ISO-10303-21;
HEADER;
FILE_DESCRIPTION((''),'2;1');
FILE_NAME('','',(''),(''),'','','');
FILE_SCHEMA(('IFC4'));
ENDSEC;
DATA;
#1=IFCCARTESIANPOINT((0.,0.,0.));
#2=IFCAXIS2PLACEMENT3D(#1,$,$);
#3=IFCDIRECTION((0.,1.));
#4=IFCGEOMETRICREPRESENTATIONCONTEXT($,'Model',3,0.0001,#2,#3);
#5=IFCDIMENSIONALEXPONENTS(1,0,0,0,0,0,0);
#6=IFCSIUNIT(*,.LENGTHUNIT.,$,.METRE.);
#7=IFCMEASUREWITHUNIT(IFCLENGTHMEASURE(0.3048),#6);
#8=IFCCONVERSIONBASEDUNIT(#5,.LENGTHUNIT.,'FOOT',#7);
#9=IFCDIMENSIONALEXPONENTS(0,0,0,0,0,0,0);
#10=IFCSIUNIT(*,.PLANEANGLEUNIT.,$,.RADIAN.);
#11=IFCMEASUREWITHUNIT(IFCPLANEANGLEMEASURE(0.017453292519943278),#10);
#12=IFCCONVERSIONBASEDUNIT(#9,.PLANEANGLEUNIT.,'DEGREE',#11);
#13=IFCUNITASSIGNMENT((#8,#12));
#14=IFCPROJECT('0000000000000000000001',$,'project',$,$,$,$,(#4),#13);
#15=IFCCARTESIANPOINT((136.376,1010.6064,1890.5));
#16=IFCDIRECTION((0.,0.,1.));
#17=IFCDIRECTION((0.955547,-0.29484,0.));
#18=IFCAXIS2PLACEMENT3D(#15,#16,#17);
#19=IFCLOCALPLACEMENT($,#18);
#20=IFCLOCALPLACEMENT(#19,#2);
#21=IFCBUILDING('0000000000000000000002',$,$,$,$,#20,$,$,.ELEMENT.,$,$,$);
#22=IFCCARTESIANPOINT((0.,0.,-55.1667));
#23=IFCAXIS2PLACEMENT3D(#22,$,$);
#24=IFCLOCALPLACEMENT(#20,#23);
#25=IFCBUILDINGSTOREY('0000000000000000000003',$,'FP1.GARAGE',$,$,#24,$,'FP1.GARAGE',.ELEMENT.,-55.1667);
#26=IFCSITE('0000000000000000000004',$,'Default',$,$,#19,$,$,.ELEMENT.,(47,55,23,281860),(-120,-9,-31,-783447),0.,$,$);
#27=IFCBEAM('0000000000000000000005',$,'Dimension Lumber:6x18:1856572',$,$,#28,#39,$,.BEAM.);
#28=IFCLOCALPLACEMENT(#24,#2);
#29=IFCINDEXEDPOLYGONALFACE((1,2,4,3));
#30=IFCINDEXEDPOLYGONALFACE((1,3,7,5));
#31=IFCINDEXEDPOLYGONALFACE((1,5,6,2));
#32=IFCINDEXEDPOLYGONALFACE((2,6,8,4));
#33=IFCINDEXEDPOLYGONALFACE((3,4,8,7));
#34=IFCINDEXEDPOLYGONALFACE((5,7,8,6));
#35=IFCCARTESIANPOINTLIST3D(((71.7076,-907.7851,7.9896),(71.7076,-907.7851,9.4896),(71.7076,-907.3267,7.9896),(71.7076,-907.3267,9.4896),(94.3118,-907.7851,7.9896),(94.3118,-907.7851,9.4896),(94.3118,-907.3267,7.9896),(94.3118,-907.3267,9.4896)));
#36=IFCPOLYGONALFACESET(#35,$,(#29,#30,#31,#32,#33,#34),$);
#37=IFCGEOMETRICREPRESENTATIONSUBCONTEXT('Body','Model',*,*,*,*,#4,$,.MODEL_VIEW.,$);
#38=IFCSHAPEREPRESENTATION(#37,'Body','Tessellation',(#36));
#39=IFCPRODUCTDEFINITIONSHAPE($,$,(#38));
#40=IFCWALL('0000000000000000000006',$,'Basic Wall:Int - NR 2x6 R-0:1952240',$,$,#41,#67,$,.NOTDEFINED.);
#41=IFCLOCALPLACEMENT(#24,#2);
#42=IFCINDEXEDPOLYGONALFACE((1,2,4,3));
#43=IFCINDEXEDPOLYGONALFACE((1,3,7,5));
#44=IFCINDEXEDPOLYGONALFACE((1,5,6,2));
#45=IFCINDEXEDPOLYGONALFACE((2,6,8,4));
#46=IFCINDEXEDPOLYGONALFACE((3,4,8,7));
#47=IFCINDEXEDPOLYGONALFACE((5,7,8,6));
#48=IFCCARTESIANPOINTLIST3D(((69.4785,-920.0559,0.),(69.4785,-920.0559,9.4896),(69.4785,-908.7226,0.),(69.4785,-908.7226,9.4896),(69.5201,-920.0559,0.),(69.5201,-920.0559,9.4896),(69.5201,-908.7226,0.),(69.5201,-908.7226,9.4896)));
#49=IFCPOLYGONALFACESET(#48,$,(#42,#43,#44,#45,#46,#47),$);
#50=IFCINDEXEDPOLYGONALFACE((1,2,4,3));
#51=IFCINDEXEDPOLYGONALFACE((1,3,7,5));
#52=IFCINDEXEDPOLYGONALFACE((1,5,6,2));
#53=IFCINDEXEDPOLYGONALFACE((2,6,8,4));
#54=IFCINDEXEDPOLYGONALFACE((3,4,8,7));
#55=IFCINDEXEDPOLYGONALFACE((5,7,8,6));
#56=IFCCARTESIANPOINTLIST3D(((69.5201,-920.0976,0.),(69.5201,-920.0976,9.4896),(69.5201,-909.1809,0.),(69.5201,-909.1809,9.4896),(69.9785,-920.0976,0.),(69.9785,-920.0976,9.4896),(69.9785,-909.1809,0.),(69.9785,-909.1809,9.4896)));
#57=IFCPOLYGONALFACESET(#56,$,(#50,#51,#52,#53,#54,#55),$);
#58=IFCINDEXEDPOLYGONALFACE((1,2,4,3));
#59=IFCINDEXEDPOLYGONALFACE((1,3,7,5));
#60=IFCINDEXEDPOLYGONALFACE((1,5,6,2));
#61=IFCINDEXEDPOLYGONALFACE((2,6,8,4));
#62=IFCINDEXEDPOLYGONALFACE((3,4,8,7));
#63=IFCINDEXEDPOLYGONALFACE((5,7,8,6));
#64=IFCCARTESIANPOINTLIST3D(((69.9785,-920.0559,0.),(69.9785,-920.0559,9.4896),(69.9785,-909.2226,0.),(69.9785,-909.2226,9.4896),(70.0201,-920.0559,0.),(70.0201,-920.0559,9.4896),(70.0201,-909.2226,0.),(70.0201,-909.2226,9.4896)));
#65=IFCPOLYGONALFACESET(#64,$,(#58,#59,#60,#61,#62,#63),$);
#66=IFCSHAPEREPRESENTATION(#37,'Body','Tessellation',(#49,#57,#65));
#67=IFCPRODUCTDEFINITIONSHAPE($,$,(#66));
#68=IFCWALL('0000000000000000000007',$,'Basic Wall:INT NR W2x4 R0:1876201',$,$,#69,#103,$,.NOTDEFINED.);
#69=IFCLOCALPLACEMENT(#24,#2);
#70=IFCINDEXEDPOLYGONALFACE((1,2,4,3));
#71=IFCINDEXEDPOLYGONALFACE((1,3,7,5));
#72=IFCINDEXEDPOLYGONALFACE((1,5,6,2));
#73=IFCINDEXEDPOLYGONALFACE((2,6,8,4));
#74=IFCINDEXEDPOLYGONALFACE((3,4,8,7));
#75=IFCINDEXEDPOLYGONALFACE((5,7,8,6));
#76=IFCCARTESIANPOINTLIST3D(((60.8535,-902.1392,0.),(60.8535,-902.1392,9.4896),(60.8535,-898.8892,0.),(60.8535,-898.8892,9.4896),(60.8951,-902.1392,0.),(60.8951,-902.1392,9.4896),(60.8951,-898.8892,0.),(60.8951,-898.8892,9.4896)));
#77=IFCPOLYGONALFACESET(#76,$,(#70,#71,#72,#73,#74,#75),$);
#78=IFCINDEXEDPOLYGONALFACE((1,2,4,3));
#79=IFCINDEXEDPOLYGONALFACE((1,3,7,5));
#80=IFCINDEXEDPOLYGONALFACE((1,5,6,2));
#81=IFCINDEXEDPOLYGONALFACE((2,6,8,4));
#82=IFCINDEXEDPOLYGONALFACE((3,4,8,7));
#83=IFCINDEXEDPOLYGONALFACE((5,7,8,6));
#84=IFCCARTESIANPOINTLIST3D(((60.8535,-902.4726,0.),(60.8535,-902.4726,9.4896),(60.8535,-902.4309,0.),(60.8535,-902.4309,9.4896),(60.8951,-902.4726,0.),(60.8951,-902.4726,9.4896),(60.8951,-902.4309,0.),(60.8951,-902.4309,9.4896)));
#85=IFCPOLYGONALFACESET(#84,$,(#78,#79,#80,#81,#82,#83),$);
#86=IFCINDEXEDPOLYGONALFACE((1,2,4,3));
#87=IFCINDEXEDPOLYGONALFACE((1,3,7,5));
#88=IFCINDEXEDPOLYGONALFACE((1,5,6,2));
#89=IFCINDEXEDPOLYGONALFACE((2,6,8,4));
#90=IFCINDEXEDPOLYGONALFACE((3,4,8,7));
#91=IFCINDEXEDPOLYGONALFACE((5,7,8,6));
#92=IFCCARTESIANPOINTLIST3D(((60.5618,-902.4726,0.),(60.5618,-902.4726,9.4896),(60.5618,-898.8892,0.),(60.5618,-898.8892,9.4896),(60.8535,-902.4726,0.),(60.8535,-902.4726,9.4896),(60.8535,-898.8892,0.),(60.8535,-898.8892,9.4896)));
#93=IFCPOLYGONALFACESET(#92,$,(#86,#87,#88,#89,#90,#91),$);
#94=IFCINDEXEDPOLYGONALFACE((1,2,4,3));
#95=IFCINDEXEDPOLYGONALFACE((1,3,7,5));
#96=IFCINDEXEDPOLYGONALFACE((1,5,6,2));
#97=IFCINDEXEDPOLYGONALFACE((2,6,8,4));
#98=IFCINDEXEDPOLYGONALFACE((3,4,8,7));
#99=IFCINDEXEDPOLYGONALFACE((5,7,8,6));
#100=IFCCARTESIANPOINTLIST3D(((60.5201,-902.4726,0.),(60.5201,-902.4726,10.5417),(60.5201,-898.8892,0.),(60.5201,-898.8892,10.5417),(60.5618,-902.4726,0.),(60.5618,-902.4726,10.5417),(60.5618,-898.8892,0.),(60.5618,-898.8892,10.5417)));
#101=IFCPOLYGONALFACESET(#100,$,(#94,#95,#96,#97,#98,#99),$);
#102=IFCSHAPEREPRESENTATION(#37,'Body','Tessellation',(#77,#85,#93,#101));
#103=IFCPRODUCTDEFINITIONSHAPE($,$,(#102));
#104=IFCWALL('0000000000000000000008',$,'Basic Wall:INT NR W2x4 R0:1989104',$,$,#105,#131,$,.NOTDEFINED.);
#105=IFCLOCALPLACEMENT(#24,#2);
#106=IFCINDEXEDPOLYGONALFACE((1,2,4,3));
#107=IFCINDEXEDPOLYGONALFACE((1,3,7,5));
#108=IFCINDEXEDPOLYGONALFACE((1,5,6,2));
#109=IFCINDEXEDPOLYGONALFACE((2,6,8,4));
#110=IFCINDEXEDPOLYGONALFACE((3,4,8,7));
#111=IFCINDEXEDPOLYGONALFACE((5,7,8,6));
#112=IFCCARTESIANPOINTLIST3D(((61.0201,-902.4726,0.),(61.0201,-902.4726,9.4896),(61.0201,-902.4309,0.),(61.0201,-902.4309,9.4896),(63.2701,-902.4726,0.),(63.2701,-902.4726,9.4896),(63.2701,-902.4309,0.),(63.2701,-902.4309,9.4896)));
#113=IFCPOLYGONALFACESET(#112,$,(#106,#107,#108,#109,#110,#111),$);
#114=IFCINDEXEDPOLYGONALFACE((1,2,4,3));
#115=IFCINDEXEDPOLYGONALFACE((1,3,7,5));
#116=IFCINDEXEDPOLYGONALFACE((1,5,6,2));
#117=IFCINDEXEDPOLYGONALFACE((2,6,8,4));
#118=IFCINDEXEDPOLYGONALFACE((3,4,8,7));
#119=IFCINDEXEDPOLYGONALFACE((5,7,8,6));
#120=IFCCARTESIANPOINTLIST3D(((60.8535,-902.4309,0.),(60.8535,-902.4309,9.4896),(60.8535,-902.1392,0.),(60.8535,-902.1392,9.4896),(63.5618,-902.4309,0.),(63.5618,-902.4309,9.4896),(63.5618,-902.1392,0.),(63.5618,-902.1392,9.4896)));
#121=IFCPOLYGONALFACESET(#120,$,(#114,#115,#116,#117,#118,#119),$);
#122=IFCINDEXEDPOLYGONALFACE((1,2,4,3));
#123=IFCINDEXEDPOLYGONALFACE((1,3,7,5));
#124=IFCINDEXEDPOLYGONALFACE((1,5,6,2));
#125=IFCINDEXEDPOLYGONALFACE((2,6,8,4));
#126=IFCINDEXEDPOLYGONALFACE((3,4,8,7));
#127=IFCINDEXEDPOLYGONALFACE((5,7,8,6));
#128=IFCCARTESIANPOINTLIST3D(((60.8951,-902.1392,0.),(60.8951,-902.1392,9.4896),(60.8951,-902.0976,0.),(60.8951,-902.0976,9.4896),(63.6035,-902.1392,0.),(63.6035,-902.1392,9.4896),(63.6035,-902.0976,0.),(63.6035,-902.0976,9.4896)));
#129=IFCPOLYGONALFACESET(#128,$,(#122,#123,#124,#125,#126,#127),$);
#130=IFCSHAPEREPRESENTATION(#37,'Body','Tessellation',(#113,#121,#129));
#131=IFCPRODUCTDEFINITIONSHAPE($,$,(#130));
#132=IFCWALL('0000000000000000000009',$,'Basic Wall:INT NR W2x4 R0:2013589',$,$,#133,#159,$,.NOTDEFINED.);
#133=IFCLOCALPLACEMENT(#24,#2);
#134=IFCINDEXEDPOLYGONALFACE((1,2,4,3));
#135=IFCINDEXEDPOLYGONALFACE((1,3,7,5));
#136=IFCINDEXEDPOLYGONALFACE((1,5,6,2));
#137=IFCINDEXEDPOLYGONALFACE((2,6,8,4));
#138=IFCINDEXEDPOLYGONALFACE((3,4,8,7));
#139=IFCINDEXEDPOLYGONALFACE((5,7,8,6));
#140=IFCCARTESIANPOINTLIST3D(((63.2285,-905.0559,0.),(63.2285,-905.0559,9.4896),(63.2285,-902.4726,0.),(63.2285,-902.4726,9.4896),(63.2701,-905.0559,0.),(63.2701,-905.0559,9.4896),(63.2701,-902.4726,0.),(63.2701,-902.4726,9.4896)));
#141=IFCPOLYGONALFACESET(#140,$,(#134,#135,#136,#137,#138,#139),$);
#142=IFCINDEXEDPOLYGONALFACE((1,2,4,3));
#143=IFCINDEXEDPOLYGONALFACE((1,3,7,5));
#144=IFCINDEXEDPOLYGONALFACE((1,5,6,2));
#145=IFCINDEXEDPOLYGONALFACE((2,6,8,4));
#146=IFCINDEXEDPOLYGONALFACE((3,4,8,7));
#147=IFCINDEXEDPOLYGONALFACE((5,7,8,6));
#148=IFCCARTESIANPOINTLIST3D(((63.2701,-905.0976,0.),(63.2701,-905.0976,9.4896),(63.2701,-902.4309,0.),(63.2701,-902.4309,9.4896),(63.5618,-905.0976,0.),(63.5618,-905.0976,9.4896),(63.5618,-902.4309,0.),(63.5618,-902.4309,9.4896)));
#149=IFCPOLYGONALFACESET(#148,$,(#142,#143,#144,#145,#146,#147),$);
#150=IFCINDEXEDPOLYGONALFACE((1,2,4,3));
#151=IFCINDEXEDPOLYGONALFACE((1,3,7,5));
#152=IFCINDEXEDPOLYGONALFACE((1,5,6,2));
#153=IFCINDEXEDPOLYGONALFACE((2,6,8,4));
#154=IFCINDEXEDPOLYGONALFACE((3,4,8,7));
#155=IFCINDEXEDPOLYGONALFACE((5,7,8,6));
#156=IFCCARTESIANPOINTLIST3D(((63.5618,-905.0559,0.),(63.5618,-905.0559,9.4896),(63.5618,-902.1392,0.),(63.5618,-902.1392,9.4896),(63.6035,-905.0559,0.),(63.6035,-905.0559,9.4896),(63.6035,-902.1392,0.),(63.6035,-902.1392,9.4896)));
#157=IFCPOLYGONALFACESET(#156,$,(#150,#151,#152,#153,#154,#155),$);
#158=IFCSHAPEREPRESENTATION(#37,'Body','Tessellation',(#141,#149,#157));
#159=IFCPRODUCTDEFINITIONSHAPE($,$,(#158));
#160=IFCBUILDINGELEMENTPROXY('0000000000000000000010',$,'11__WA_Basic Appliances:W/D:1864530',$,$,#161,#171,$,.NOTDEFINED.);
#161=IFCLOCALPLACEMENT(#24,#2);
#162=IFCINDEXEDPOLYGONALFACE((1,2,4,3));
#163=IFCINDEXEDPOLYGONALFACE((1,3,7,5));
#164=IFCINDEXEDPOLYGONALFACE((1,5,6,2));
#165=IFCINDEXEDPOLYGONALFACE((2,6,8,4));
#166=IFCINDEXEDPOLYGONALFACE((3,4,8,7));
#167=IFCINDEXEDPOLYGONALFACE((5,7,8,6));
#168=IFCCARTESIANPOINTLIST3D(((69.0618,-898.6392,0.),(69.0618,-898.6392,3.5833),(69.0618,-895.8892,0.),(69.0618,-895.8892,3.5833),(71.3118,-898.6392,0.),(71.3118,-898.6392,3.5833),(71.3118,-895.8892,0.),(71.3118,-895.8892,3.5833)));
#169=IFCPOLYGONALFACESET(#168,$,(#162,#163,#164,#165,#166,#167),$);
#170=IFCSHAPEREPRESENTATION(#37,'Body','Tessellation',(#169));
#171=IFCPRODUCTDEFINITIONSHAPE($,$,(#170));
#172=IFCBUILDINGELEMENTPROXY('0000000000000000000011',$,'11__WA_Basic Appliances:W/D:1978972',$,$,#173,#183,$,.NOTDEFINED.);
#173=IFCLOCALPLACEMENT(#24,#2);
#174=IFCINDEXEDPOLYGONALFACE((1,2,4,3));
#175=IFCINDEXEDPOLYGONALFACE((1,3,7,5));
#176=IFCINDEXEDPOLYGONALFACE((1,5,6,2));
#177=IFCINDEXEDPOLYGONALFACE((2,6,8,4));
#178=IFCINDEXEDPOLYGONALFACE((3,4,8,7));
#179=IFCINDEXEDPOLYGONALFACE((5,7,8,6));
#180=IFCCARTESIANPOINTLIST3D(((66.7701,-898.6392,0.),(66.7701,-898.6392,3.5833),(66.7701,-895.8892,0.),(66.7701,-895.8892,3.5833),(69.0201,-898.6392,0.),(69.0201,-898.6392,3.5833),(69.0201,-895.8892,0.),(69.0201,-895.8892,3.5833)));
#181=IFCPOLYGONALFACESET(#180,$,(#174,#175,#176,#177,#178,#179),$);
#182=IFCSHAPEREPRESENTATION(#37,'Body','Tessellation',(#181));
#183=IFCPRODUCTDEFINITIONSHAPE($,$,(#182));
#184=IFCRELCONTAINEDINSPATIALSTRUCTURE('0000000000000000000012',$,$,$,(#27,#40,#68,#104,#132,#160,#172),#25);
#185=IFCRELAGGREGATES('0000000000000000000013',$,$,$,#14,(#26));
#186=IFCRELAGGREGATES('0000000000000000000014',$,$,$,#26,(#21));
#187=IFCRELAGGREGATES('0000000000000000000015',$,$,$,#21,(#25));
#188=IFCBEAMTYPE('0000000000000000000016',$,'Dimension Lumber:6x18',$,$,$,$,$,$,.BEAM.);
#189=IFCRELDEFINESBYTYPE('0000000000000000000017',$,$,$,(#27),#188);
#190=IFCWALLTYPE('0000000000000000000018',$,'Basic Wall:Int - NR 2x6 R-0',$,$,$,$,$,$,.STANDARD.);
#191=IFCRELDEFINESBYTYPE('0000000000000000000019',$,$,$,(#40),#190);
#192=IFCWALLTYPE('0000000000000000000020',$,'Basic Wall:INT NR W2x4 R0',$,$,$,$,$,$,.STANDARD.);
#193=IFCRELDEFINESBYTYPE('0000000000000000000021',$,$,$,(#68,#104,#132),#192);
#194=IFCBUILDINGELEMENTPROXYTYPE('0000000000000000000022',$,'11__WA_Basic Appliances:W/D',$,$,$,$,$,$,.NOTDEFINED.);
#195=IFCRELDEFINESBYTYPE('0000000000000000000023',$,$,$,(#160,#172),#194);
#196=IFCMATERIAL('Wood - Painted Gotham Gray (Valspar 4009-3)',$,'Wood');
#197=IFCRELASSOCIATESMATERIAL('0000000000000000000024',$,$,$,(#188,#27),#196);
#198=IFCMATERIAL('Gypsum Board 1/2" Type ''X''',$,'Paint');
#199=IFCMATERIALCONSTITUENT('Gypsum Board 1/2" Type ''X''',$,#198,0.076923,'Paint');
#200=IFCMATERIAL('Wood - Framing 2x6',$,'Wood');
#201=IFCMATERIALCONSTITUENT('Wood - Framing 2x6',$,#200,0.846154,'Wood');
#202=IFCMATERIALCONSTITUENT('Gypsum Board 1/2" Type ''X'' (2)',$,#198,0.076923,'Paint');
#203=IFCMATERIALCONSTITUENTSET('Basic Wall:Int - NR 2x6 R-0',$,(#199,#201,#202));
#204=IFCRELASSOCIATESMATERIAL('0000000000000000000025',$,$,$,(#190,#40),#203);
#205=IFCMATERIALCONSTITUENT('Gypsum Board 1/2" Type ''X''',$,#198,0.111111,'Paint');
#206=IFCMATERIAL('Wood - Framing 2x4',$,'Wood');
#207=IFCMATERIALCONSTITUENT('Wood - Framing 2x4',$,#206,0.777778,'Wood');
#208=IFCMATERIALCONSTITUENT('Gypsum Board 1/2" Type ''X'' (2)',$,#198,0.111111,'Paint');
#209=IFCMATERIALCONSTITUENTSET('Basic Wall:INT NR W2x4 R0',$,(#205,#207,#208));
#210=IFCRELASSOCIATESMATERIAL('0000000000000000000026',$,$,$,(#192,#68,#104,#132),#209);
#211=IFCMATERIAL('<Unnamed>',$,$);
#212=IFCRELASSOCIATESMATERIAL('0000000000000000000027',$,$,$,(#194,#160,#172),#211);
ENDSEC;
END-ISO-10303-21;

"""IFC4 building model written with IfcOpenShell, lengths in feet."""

from ifc_helpers import new_model, entity, si_unit, converted_unit, direction, frame, origin, place, context, subcontext, project, spatial, indexed_curve, outline, extrude, source, transform, mapped, material, constituent, constituent_set, type_object, type_shapes, element, save


model = new_model("IFC4")

# Units and contexts
model_context = context("Model", 3, precision=0.0001, world=origin(), true_north=direction((0.0, 1.0)))
body_context = subcontext(model_context, "Body", "Model", "MODEL_VIEW")
ifc_project = project(units=[converted_unit("LENGTHUNIT", "FOOT", entity("IfcLengthMeasure", 0.3048), si_unit("LENGTHUNIT", "METRE"), dimensions=[1, 0, 0, 0, 0, 0, 0]), converted_unit("PLANEANGLEUNIT", "DEGREE", entity("IfcPlaneAngleMeasure", 0.017453292519943278), si_unit("PLANEANGLEUNIT", "RADIAN"), dimensions=[0, 0, 0, 0, 0, 0, 0])], contexts=[model_context])

# Site, building, storey
site_placement = place(None, frame((136.376, 1010.6064, 1890.5), z_axis=(0.0, 0.0, 1.0), x_axis=(0.955547, -0.29484, 0.0)))
site = spatial("IfcSite", under=ifc_project, at=site_placement, Name="Default", CompositionType="ELEMENT", RefLatitude=(47, 55, 23, 281860), RefLongitude=(-120, -9, -31, -783447), RefElevation=0.0)
building_placement = place(site_placement, origin())
building = spatial("IfcBuilding", under=site, at=building_placement, CompositionType="ELEMENT")
storey_placement = place(building_placement, frame((0.0, 0.0, -55.1667)))
storey = spatial("IfcBuildingStorey", under=building, at=storey_placement, Name="FP1.GARAGE", LongName="FP1.GARAGE", CompositionType="ELEMENT", Elevation=-55.1667)

# Beam
ifc_material_1 = material(Name="Wood - Painted Gotham Gray (Valspar 4009-3)", Category="Wood")
beam_type = type_object("IfcBeamType", Name="Dimension Lumber:6x18", PredefinedType="BEAM", material=ifc_material_1)
shared_shape_1 = source(origin(), body_context, "Body", "SweptSolid", [
    extrude(outline(indexed_curve([(-0.75, -0.2292), (0.75, -0.2292), (0.75, 0.2292), (-0.75, 0.2292), (-0.75, -0.2292)], self_intersect=False)), frame((-11.3021, 0.0, 0.0), z_axis=(1.0, 0.0, 0.0), x_axis=(0.0, 0.0, -1.0)), (0.0, 0.0, 1.0), 22.6042),
])
type_shapes(beam_type, [shared_shape_1])
beam_placement = place(storey_placement, frame((83.0097, -907.5559, 8.7396)))
element("IfcBeam", 1, at=beam_placement, inside=storey, type_object=beam_type, material=ifc_material_1, Name="Dimension Lumber:6x18:1856572", PredefinedType="BEAM", context=body_context, shape_type="MappedRepresentation", body=[
    mapped(shared_shape_1, transform((0.0, 0.0, 0.0), scale=1.0)),
])

# Shared definitions
ifc_material_2 = material(Name="Gypsum Board 1/2\" Type 'X'", Category="Paint")
ifc_material_3 = material(Name="<Unnamed>")

# Walls
ifc_constituent_1 = constituent(ifc_material_2, Name="Gypsum Board 1/2\" Type 'X'", Category="Paint", fraction=0.076923)
ifc_material_4 = material(Name="Wood - Framing 2x6", Category="Wood")
ifc_constituent_2 = constituent(ifc_material_4, Name="Wood - Framing 2x6", Category="Wood", fraction=0.846154)
ifc_constituent_3 = constituent(ifc_material_2, Name="Gypsum Board 1/2\" Type 'X' (2)", Category="Paint", fraction=0.076923)
ifc_constituent_set_1 = constituent_set(constituents=[ifc_constituent_1, ifc_constituent_2, ifc_constituent_3], Name="Basic Wall:Int - NR 2x6 R-0")
wall_type_1 = type_object("IfcWallType", Name="Basic Wall:Int - NR 2x6 R-0", PredefinedType="STANDARD", material=ifc_constituent_set_1)
wall_1_placement = place(storey_placement, frame((69.7493, -920.0559, 0.0), z_axis=(0.0, 0.0, 1.0), x_axis=(0.0, 1.0, 0.0)))
element("IfcWall", 2, at=wall_1_placement, inside=storey, type_object=wall_type_1, material=ifc_constituent_set_1, Name="Basic Wall:Int - NR 2x6 R-0:1952240", PredefinedType="NOTDEFINED", context=body_context, shape_type="SweptSolid", body=[
    extrude(outline(indexed_curve([(-0.0208, -5.6667), (0.0208, -5.6667), (0.0208, 5.6667), (-0.0208, 5.6667), (-0.0208, -5.6667)], self_intersect=False)), frame((5.6667, 0.25, 0.0), z_axis=(0.0, 0.0, 1.0), x_axis=(0.0, -1.0, 0.0)), (0.0, 0.0, 1.0), 9.4896),
    extrude(outline(indexed_curve([(-5.4583, -0.2292), (5.4583, -0.2292), (5.4583, 0.2292), (-5.4583, 0.2292), (-5.4583, -0.2292)], self_intersect=False)), frame((5.4167, 0.0, 0.0)), (0.0, 0.0, 1.0), 9.4896),
    extrude(outline(indexed_curve([(-0.0208, -5.4167), (0.0208, -5.4167), (0.0208, 5.4167), (-0.0208, 5.4167), (-0.0208, -5.4167)], self_intersect=False)), frame((5.4167, -0.25, 0.0), z_axis=(0.0, 0.0, 1.0), x_axis=(0.0, 1.0, 0.0)), (0.0, 0.0, 1.0), 9.4896),
])
ifc_constituent_4 = constituent(ifc_material_2, Name="Gypsum Board 1/2\" Type 'X'", Category="Paint", fraction=0.111111)
ifc_material_5 = material(Name="Wood - Framing 2x4", Category="Wood")
ifc_constituent_5 = constituent(ifc_material_5, Name="Wood - Framing 2x4", Category="Wood", fraction=0.777778)
ifc_constituent_6 = constituent(ifc_material_2, Name="Gypsum Board 1/2\" Type 'X' (2)", Category="Paint", fraction=0.111111)
ifc_constituent_set_2 = constituent_set(constituents=[ifc_constituent_4, ifc_constituent_5, ifc_constituent_6], Name="Basic Wall:INT NR W2x4 R0")
wall_type_2 = type_object("IfcWallType", Name="Basic Wall:INT NR W2x4 R0", PredefinedType="STANDARD", material=ifc_constituent_set_2)
wall_2_placement = place(storey_placement, frame((60.7076, -898.8892, 0.0), z_axis=(0.0, 0.0, 1.0), x_axis=(0.0, -1.0, 0.0)))
element("IfcWall", 3, at=wall_2_placement, inside=storey, type_object=wall_type_2, material=ifc_constituent_set_2, Name="Basic Wall:INT NR W2x4 R0:1876201", PredefinedType="NOTDEFINED", context=body_context, shape_type="SweptSolid", body=[
    extrude(outline(indexed_curve([(-1.625, -0.0208), (1.625, -0.0208), (1.625, 0.0208), (-1.625, 0.0208), (-1.625, -0.0208)], self_intersect=False)), frame((1.625, 0.1667, 0.0)), (0.0, 0.0, 1.0), 9.4896),
    extrude(outline(indexed_curve([(-0.0208, -0.0208), (0.0208, -0.0208), (0.0208, 0.0208), (-0.0208, 0.0208), (-0.0208, -0.0208)], self_intersect=False)), frame((3.5625, 0.1667, 0.0), z_axis=(0.0, 0.0, 1.0), x_axis=(-1.0, 0.0, 0.0)), (0.0, 0.0, 1.0), 9.4896),
    extrude(outline(indexed_curve([(-1.7917, -0.1458), (1.7917, -0.1458), (1.7917, 0.1458), (-1.7917, 0.1458), (-1.7917, -0.1458)], self_intersect=False)), frame((1.7917, 0.0, 0.0), z_axis=(0.0, 0.0, 1.0), x_axis=(-1.0, 0.0, 0.0)), (0.0, 0.0, 1.0), 9.4896),
    extrude(outline(indexed_curve([(-0.0208, -1.7917), (0.0208, -1.7917), (0.0208, 1.7917), (-0.0208, 1.7917), (-0.0208, -1.7917)], self_intersect=False)), frame((1.7917, -0.1667, 0.0), z_axis=(0.0, 0.0, 1.0), x_axis=(0.0, 1.0, 0.0)), (0.0, 0.0, 1.0), 10.5417),
])

# Walls
wall_3_placement = place(storey_placement, frame((60.8951, -902.2851, 0.0)))
element("IfcWall", 4, at=wall_3_placement, inside=storey, type_object=wall_type_2, material=ifc_constituent_set_2, Name="Basic Wall:INT NR W2x4 R0:1989104", PredefinedType="NOTDEFINED", context=body_context, shape_type="SweptSolid", body=[
    extrude(outline(indexed_curve([(-1.125, -0.0208), (1.125, -0.0208), (1.125, 0.0208), (-1.125, 0.0208), (-1.125, -0.0208)], self_intersect=False)), frame((1.25, -0.1667, 0.0), z_axis=(0.0, 0.0, 1.0), x_axis=(-1.0, 0.0, 0.0)), (0.0, 0.0, 1.0), 9.4896),
    extrude(outline(indexed_curve([(-1.3542, -0.1458), (1.3542, -0.1458), (1.3542, 0.1458), (-1.3542, 0.1458), (-1.3542, -0.1458)], self_intersect=False)), frame((1.3125, 0.0, 0.0)), (0.0, 0.0, 1.0), 9.4896),
    extrude(outline(indexed_curve([(-0.0208, -1.3542), (0.0208, -1.3542), (0.0208, 1.3542), (-0.0208, 1.3542), (-0.0208, -1.3542)], self_intersect=False)), frame((1.3542, 0.1667, 0.0), z_axis=(0.0, 0.0, 1.0), x_axis=(0.0, -1.0, 0.0)), (0.0, 0.0, 1.0), 9.4896),
])
wall_4_placement = place(storey_placement, frame((63.416, -902.4726, 0.0), z_axis=(0.0, 0.0, 1.0), x_axis=(0.0, -1.0, 0.0)))
element("IfcWall", 5, at=wall_4_placement, inside=storey, type_object=wall_type_2, material=ifc_constituent_set_2, Name="Basic Wall:INT NR W2x4 R0:2013589", PredefinedType="NOTDEFINED", context=body_context, shape_type="SweptSolid", body=[
    extrude(outline(indexed_curve([(-0.0208, -1.2917), (0.0208, -1.2917), (0.0208, 1.2917), (-0.0208, 1.2917), (-0.0208, -1.2917)], self_intersect=False)), frame((1.2917, -0.1667, 0.0), z_axis=(0.0, 0.0, 1.0), x_axis=(0.0, 1.0, 0.0)), (0.0, 0.0, 1.0), 9.4896),
    extrude(outline(indexed_curve([(-1.3333, -0.1458), (1.3333, -0.1458), (1.3333, 0.1458), (-1.3333, 0.1458), (-1.3333, -0.1458)], self_intersect=False)), frame((1.2917, 0.0, 0.0)), (0.0, 0.0, 1.0), 9.4896),
    extrude(outline(indexed_curve([(-0.0208, -1.4583), (0.0208, -1.4583), (0.0208, 1.4583), (-0.0208, 1.4583), (-0.0208, -1.4583)], self_intersect=False)), frame((1.125, 0.1667, 0.0), z_axis=(0.0, 0.0, 1.0), x_axis=(0.0, -1.0, 0.0)), (0.0, 0.0, 1.0), 9.4896),
])

# Building element proxies
building_element_proxy_type_1 = type_object("IfcBuildingElementProxyType", Name="11__WA_Basic Appliances:W/D", PredefinedType="NOTDEFINED", material=ifc_material_3)
shared_shape_2 = source(origin(), body_context, "Body", "SweptSolid", [
    extrude(outline(indexed_curve([(-1.375, -1.125), (1.375, -1.125), (1.375, 1.125), (-1.375, 1.125), (-1.375, -1.125)], self_intersect=False)), frame((0.0, 0.0, 0.0), z_axis=(0.0, 0.0, 1.0), x_axis=(0.0, 1.0, 0.0)), (0.0, 0.0, 1.0), 3.5833),
])
type_shapes(building_element_proxy_type_1, [shared_shape_2])
for number, where, z_axis, x_axis, name in (
    (6, (70.1868, -897.2642, 0.0), (0.0, 0.0, 1.0), (-1.0, 0.0, 0.0), "11__WA_Basic Appliances:W/D:1864530"),
    (7, (67.8951, -897.2642, 0.0), (0.0, 0.0, 1.0), (-1.0, 0.0, 0.0), "11__WA_Basic Appliances:W/D:1978972"),
):
    element("IfcBuildingElementProxy", number, at=place(storey_placement, frame(where, z_axis=z_axis, x_axis=x_axis)), inside=storey, type_object=building_element_proxy_type_1, material=ifc_material_3, Name=name, PredefinedType="NOTDEFINED", context=body_context, shape_type="MappedRepresentation", body=[
        mapped(shared_shape_2, transform((0.0, 0.0, 0.0), scale=1.0)),
    ])

save(model, "model.ifc")
